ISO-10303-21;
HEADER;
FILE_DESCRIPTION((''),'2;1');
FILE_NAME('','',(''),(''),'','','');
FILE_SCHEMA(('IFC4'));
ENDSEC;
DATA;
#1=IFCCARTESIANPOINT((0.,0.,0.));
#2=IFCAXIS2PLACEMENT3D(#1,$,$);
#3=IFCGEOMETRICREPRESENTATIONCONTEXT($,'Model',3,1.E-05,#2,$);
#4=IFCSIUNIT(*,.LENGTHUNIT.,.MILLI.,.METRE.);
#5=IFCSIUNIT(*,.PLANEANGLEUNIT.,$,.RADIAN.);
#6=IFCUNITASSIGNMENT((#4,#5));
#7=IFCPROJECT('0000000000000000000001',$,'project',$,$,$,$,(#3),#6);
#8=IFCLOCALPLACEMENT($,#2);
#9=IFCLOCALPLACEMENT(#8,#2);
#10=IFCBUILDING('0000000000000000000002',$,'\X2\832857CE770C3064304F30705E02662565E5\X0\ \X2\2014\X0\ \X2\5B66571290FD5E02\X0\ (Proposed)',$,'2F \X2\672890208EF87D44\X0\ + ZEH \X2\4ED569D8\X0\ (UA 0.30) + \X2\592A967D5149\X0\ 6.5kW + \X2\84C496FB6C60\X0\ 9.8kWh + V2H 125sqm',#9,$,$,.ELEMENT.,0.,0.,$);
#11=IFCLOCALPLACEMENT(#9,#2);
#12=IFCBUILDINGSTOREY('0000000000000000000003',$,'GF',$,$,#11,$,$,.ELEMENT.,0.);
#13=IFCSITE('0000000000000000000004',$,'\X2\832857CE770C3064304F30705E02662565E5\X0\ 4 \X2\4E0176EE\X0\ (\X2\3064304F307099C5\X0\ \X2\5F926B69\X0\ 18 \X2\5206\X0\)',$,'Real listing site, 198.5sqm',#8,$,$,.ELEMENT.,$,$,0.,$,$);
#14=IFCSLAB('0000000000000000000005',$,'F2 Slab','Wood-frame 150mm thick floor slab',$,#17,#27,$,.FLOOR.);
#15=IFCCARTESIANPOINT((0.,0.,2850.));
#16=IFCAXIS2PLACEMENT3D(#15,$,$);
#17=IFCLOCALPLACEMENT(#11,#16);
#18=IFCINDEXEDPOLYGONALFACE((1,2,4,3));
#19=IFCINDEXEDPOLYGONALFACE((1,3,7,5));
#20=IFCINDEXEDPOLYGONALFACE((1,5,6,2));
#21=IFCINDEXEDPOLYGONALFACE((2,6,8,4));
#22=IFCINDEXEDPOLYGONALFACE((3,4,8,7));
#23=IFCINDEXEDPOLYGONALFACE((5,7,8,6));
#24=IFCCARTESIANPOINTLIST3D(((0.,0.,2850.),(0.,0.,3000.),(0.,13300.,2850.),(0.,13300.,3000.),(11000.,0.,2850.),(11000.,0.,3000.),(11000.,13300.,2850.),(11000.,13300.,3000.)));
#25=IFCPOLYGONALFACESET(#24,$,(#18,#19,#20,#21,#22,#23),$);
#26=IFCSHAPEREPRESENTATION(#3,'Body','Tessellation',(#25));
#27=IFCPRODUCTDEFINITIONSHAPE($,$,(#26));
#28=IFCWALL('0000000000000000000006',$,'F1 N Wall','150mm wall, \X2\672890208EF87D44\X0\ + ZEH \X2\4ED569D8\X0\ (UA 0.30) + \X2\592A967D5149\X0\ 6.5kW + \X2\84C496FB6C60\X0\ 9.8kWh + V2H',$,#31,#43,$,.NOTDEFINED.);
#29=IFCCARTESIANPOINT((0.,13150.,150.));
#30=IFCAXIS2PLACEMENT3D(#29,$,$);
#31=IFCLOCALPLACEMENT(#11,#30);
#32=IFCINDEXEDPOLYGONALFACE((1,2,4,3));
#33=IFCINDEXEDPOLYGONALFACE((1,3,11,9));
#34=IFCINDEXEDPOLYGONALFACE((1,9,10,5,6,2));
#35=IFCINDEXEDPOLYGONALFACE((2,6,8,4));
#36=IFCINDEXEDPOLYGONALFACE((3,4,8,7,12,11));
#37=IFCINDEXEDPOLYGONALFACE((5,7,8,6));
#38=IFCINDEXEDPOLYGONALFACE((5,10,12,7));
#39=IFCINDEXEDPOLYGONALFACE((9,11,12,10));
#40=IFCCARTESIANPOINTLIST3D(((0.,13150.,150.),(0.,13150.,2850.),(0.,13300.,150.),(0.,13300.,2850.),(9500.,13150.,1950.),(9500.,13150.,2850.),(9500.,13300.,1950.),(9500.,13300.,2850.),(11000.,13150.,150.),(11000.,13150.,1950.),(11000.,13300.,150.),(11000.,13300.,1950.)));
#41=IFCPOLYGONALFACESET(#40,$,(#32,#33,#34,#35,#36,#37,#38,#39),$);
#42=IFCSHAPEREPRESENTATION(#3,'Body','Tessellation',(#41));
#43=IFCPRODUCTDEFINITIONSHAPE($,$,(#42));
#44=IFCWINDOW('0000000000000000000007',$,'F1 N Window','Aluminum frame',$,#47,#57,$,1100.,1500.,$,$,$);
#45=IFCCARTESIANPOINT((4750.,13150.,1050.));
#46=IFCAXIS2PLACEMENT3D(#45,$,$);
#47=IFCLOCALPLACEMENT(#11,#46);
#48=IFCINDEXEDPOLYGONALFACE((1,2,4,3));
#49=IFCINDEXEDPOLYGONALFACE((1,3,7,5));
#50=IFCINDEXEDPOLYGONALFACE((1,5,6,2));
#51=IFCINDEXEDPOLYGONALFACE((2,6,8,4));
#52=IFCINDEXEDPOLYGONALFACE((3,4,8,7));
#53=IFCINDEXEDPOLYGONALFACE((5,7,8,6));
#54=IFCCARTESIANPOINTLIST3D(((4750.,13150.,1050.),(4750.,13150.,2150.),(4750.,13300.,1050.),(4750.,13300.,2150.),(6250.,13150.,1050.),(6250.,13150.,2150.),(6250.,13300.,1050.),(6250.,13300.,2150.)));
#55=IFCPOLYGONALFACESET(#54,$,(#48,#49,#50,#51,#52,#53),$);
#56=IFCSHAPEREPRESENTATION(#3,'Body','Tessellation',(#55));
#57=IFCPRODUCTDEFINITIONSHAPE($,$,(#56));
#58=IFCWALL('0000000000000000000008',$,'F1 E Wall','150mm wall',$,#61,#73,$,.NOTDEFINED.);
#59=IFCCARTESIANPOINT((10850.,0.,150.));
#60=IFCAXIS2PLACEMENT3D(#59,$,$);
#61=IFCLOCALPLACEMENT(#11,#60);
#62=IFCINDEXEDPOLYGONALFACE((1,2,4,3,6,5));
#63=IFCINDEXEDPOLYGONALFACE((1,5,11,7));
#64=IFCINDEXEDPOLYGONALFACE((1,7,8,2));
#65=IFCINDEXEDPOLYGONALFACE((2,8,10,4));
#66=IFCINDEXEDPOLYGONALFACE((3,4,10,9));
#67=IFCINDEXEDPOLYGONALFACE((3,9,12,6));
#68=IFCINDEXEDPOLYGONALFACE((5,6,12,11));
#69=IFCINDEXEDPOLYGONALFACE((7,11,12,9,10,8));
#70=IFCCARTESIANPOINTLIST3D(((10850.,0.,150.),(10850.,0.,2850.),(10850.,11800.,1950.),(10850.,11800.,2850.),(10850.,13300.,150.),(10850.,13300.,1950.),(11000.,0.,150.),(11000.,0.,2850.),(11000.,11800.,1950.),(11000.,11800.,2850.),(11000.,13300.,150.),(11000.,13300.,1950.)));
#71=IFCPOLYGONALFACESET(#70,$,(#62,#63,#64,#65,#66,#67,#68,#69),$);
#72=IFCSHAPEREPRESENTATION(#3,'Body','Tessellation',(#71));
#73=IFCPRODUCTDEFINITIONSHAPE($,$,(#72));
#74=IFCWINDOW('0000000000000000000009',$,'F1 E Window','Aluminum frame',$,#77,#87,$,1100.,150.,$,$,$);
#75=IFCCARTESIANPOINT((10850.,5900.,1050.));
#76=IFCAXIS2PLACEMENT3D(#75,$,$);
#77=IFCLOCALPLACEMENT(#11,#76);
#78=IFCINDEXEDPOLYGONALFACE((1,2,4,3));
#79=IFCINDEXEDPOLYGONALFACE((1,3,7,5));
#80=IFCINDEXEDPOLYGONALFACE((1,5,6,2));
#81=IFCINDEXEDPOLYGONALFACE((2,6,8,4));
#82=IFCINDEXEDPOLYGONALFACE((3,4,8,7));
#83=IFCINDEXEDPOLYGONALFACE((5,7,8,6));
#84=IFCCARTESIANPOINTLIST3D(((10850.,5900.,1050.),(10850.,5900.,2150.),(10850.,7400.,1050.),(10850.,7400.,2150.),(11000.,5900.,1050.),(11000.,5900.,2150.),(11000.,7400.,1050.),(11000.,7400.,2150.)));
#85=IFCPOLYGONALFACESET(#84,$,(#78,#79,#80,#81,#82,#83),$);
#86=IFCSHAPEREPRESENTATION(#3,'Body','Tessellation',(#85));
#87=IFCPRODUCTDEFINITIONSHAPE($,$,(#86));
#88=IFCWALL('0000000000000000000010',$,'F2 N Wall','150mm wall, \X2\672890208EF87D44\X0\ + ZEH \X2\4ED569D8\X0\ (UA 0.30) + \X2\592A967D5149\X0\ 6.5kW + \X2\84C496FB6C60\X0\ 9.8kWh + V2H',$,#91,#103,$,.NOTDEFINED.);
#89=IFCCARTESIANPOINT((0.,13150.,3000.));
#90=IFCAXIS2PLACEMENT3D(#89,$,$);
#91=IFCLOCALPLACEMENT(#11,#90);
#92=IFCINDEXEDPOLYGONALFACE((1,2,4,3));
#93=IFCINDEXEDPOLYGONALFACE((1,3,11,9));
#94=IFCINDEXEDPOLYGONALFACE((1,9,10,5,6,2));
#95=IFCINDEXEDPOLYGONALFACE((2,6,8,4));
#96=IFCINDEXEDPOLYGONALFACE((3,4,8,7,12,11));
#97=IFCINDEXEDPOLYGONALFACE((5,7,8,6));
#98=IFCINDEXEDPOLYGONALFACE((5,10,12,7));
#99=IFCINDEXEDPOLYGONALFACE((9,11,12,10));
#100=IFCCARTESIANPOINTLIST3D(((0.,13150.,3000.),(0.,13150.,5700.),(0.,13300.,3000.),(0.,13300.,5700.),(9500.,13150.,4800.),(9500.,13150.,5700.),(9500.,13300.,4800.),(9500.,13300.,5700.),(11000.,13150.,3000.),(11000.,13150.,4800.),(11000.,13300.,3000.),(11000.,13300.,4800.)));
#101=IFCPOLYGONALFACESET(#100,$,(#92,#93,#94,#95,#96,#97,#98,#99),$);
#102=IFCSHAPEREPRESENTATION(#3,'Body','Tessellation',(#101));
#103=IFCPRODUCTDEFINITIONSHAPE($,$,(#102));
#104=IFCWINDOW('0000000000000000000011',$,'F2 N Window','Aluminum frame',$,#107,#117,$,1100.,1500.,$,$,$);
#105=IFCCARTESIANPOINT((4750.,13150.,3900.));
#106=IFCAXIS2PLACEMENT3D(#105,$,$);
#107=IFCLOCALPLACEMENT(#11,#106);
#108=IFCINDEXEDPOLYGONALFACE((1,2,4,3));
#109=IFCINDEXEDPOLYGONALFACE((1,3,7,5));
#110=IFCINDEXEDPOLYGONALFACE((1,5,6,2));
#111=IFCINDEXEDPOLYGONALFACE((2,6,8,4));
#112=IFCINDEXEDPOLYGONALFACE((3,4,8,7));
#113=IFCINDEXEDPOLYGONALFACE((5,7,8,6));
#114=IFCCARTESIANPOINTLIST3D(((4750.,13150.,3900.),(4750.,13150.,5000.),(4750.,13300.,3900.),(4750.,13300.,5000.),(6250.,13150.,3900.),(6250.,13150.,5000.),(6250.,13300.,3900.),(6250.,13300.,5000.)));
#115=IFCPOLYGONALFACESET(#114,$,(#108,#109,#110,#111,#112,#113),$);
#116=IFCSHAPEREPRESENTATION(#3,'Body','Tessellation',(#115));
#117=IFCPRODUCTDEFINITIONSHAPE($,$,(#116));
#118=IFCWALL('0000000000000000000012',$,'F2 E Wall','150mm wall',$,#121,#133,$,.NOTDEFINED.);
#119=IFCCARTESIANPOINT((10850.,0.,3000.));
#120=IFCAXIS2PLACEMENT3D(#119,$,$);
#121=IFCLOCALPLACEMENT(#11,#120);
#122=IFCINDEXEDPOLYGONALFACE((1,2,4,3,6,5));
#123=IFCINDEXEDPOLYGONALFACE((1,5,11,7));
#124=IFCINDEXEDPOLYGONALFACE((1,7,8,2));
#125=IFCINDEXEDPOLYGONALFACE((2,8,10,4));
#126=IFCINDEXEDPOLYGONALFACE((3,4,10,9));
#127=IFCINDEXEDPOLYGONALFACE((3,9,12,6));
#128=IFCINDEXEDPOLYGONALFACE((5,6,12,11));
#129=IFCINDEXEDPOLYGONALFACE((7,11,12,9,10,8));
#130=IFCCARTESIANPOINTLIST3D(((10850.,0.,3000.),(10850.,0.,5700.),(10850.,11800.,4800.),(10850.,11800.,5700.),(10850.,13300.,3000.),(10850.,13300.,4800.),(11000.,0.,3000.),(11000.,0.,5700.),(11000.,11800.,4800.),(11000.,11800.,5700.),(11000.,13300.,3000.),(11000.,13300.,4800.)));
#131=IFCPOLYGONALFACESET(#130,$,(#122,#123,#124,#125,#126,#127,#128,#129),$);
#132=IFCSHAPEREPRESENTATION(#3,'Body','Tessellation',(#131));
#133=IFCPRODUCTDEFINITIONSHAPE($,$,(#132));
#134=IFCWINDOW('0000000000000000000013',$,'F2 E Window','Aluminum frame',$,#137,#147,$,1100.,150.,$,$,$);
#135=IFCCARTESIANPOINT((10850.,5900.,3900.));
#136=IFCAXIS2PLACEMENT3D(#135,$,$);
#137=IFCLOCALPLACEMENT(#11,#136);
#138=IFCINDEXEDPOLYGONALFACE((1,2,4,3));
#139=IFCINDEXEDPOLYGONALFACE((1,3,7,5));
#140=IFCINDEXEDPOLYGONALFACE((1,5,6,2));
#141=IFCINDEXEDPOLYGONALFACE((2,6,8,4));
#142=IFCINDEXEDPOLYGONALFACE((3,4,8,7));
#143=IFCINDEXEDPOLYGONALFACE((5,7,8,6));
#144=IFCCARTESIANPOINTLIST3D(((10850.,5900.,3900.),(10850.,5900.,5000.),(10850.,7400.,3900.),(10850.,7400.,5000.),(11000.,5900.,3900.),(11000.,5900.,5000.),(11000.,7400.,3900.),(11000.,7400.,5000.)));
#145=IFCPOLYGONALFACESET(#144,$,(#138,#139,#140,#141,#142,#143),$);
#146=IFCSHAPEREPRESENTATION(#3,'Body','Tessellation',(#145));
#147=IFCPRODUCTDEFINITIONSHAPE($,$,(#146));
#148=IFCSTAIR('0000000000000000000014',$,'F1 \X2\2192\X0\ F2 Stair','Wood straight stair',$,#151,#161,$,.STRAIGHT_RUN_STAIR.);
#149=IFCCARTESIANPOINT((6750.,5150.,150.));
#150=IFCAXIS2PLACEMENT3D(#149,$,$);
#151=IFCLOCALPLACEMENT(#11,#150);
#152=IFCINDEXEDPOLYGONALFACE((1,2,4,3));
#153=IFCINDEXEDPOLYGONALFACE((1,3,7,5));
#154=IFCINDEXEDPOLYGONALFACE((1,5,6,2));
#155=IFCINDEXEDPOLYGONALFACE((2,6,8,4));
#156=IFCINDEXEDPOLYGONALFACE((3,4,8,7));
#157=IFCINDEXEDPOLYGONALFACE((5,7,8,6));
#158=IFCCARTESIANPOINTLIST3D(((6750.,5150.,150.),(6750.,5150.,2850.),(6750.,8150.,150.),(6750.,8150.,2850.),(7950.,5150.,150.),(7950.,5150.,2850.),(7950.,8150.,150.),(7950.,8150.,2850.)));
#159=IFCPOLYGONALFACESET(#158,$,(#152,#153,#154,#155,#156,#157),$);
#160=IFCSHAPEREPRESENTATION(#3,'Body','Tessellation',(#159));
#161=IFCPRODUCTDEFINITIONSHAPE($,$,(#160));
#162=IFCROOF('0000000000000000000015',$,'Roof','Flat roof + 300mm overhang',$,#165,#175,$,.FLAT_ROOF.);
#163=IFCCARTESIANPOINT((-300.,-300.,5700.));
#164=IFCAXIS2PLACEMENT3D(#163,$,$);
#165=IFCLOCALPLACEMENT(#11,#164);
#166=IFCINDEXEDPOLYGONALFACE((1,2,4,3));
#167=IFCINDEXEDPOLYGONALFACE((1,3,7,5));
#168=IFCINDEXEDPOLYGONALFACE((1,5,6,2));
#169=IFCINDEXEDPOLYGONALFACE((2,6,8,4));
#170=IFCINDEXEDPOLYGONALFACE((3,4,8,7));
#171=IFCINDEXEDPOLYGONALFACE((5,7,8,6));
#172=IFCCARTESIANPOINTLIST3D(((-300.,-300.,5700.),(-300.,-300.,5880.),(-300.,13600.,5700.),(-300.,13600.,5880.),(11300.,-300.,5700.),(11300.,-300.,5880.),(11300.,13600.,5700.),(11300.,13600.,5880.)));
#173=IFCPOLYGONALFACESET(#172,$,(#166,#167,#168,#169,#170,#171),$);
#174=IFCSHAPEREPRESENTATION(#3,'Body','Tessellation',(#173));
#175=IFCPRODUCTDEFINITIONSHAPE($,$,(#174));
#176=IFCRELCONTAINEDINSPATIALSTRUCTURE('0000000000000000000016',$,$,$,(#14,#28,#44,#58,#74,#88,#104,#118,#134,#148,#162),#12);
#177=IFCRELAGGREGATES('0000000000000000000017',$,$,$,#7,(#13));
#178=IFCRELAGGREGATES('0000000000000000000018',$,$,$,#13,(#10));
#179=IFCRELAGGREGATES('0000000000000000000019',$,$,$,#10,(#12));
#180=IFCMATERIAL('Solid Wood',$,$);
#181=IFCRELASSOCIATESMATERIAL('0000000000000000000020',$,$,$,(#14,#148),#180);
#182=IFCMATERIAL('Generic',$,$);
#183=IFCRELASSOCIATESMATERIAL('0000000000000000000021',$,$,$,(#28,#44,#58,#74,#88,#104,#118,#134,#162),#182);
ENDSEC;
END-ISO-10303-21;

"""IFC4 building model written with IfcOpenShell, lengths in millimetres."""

from ifc_helpers import new_model, si_unit, frame, frame_2d, origin, place, context, project, spatial, rectangle, extrude, material, element, fill, save


model = new_model("IFC4")

# Units and contexts
model_context = context("Model", 3, precision=1e-05, world=origin())
ifc_project = project(units=[si_unit("LENGTHUNIT", "METRE", prefix="MILLI"), si_unit("PLANEANGLEUNIT", "RADIAN")], contexts=[model_context])

# Site, building, storey
site_placement = place(None, origin())
site = spatial("IfcSite", under=ifc_project, at=site_placement, Name="茨城県つくば市春日 4 丁目 (つくば駅 徒歩 18 分)", ObjectType="Real listing site, 198.5sqm", CompositionType="ELEMENT", RefElevation=0.0)
building_placement = place(site_placement, origin())
building = spatial("IfcBuilding", under=site, at=building_placement, Name="茨城県つくば市春日 — 学園都市 (Proposed)", ObjectType="2F 木造軸組 + ZEH 仕様 (UA 0.30) + 太陽光 6.5kW + 蓄電池 9.8kWh + V2H 125sqm", CompositionType="ELEMENT", ElevationOfRefHeight=0.0, ElevationOfTerrain=0.0)
storey_placement = place(building_placement, origin())
storey = spatial("IfcBuildingStorey", under=building, at=storey_placement, Name="GF", CompositionType="ELEMENT", Elevation=0.0)

# Slab
ifc_material_1 = material(Name="Solid Wood")
slab_1_placement = place(storey_placement, frame((0.0, 0.0, 2850.0)))
element("IfcSlab", 1, at=slab_1_placement, inside=storey, material=ifc_material_1, Name="F2 Slab", Description="Wood-frame 150mm thick floor slab", PredefinedType="FLOOR", context=model_context, shape_type="SweptSolid", body=[
    extrude(rectangle(XDim=11000.0, YDim=13300.0, at=frame_2d((5500.0, 6650.0))), frame((0.0, 0.0, 2850.0)), (0.0, 0.0, 1.0), 150.0),
])

# Wall, opening, window
ifc_material_2 = material(Name="Generic")
wall_1_placement = place(storey_placement, frame((0.0, 13150.0, 150.0)))
wall_1 = element("IfcWall", 2, at=wall_1_placement, inside=storey, material=ifc_material_2, Name="F1 N Wall", Description="150mm wall, 木造軸組 + ZEH 仕様 (UA 0.30) + 太陽光 6.5kW + 蓄電池 9.8kWh + V2H", PredefinedType="NOTDEFINED", context=model_context, shape_type="SweptSolid", body=[
    extrude(rectangle(XDim=11000.0, YDim=150.0, at=frame_2d((5500.0, 75.0))), frame((0.0, 13150.0, 150.0)), (0.0, 0.0, 1.0), 2700.0),
])
opening_1_placement = place(storey_placement, frame((4750.0, 13150.0, 1050.0)))
opening_1 = element("IfcOpeningElement", 3, at=opening_1_placement, cuts=wall_1, PredefinedType="NOTDEFINED", context=model_context, shape_type="SweptSolid", body=[
    extrude(rectangle(XDim=1500.0, YDim=150.0, at=frame_2d((750.0, 75.0))), frame((4750.0, 13150.0, 1050.0)), (0.0, 0.0, 1.0), 1100.0),
])
window_1_placement = place(storey_placement, frame((4750.0, 13150.0, 1050.0)))
window_1 = element("IfcWindow", 4, at=window_1_placement, inside=storey, material=ifc_material_2, Name="F1 N Window", Description="Aluminum frame", OverallHeight=1100.0, OverallWidth=1500.0, context=model_context, shape_type="SweptSolid", body=[
    extrude(rectangle(XDim=1500.0, YDim=150.0, at=frame_2d((750.0, 75.0))), frame((4750.0, 13150.0, 1050.0)), (0.0, 0.0, 1.0), 1100.0),
])
fill(opening_1, window_1)

# Walls, openings, windows
wall_2_placement = place(storey_placement, frame((10850.0, 0.0, 150.0)))
wall_2 = element("IfcWall", 5, at=wall_2_placement, inside=storey, material=ifc_material_2, Name="F1 E Wall", Description="150mm wall", PredefinedType="NOTDEFINED", context=model_context, shape_type="SweptSolid", body=[
    extrude(rectangle(XDim=150.0, YDim=13300.0, at=frame_2d((75.0, 6650.0))), frame((10850.0, 0.0, 150.0)), (0.0, 0.0, 1.0), 2700.0),
])
opening_2_placement = place(storey_placement, frame((10850.0, 5900.0, 1050.0)))
opening_2 = element("IfcOpeningElement", 6, at=opening_2_placement, cuts=wall_2, PredefinedType="NOTDEFINED", context=model_context, shape_type="SweptSolid", body=[
    extrude(rectangle(XDim=150.0, YDim=1500.0, at=frame_2d((75.0, 750.0))), frame((10850.0, 5900.0, 1050.0)), (0.0, 0.0, 1.0), 1100.0),
])
window_2_placement = place(storey_placement, frame((10850.0, 5900.0, 1050.0)))
window_2 = element("IfcWindow", 7, at=window_2_placement, inside=storey, material=ifc_material_2, Name="F1 E Window", Description="Aluminum frame", OverallHeight=1100.0, OverallWidth=150.0, context=model_context, shape_type="SweptSolid", body=[
    extrude(rectangle(XDim=150.0, YDim=1500.0, at=frame_2d((75.0, 750.0))), frame((10850.0, 5900.0, 1050.0)), (0.0, 0.0, 1.0), 1100.0),
])
fill(opening_2, window_2)
wall_3_placement = place(storey_placement, frame((0.0, 13150.0, 3000.0)))
wall_3 = element("IfcWall", 8, at=wall_3_placement, inside=storey, material=ifc_material_2, Name="F2 N Wall", Description="150mm wall, 木造軸組 + ZEH 仕様 (UA 0.30) + 太陽光 6.5kW + 蓄電池 9.8kWh + V2H", PredefinedType="NOTDEFINED", context=model_context, shape_type="SweptSolid", body=[
    extrude(rectangle(XDim=11000.0, YDim=150.0, at=frame_2d((5500.0, 75.0))), frame((0.0, 13150.0, 3000.0)), (0.0, 0.0, 1.0), 2700.0),
])
opening_3_placement = place(storey_placement, frame((4750.0, 13150.0, 3900.0)))
opening_3 = element("IfcOpeningElement", 9, at=opening_3_placement, cuts=wall_3, PredefinedType="NOTDEFINED", context=model_context, shape_type="SweptSolid", body=[
    extrude(rectangle(XDim=1500.0, YDim=150.0, at=frame_2d((750.0, 75.0))), frame((4750.0, 13150.0, 3900.0)), (0.0, 0.0, 1.0), 1100.0),
])
window_3_placement = place(storey_placement, frame((4750.0, 13150.0, 3900.0)))
window_3 = element("IfcWindow", 10, at=window_3_placement, inside=storey, material=ifc_material_2, Name="F2 N Window", Description="Aluminum frame", OverallHeight=1100.0, OverallWidth=1500.0, context=model_context, shape_type="SweptSolid", body=[
    extrude(rectangle(XDim=1500.0, YDim=150.0, at=frame_2d((750.0, 75.0))), frame((4750.0, 13150.0, 3900.0)), (0.0, 0.0, 1.0), 1100.0),
])
fill(opening_3, window_3)
wall_4_placement = place(storey_placement, frame((10850.0, 0.0, 3000.0)))
wall_4 = element("IfcWall", 11, at=wall_4_placement, inside=storey, material=ifc_material_2, Name="F2 E Wall", Description="150mm wall", PredefinedType="NOTDEFINED", context=model_context, shape_type="SweptSolid", body=[
    extrude(rectangle(XDim=150.0, YDim=13300.0, at=frame_2d((75.0, 6650.0))), frame((10850.0, 0.0, 3000.0)), (0.0, 0.0, 1.0), 2700.0),
])
opening_4_placement = place(storey_placement, frame((10850.0, 5900.0, 3900.0)))
opening_4 = element("IfcOpeningElement", 12, at=opening_4_placement, cuts=wall_4, PredefinedType="NOTDEFINED", context=model_context, shape_type="SweptSolid", body=[
    extrude(rectangle(XDim=150.0, YDim=1500.0, at=frame_2d((75.0, 750.0))), frame((10850.0, 5900.0, 3900.0)), (0.0, 0.0, 1.0), 1100.0),
])
window_4_placement = place(storey_placement, frame((10850.0, 5900.0, 3900.0)))
window_4 = element("IfcWindow", 13, at=window_4_placement, inside=storey, material=ifc_material_2, Name="F2 E Window", Description="Aluminum frame", OverallHeight=1100.0, OverallWidth=150.0, context=model_context, shape_type="SweptSolid", body=[
    extrude(rectangle(XDim=150.0, YDim=1500.0, at=frame_2d((75.0, 750.0))), frame((10850.0, 5900.0, 3900.0)), (0.0, 0.0, 1.0), 1100.0),
])
fill(opening_4, window_4)

# Stair
stair_placement = place(storey_placement, frame((6750.0, 5150.0, 150.0)))
element("IfcStair", 14, at=stair_placement, inside=storey, material=ifc_material_1, Name="F1 → F2 Stair", Description="Wood straight stair", PredefinedType="STRAIGHT_RUN_STAIR", context=model_context, shape_type="SweptSolid", body=[
    extrude(rectangle(XDim=1200.0, YDim=3000.0, at=frame_2d((600.0, 1500.0))), frame((6750.0, 5150.0, 150.0)), (0.0, 0.0, 1.0), 2700.0),
])

# Roof
roof_placement = place(storey_placement, frame((-300.0, -300.0, 5700.0)))
element("IfcRoof", 15, at=roof_placement, inside=storey, material=ifc_material_2, Name="Roof", Description="Flat roof + 300mm overhang", PredefinedType="FLAT_ROOF", context=model_context, shape_type="SweptSolid", body=[
    extrude(rectangle(XDim=11600.0, YDim=13900.0, at=frame_2d((5800.0, 6950.0))), frame((-300.0, -300.0, 5700.0)), (0.0, 0.0, 1.0), 180.0),
])

save(model, "model.ifc")
